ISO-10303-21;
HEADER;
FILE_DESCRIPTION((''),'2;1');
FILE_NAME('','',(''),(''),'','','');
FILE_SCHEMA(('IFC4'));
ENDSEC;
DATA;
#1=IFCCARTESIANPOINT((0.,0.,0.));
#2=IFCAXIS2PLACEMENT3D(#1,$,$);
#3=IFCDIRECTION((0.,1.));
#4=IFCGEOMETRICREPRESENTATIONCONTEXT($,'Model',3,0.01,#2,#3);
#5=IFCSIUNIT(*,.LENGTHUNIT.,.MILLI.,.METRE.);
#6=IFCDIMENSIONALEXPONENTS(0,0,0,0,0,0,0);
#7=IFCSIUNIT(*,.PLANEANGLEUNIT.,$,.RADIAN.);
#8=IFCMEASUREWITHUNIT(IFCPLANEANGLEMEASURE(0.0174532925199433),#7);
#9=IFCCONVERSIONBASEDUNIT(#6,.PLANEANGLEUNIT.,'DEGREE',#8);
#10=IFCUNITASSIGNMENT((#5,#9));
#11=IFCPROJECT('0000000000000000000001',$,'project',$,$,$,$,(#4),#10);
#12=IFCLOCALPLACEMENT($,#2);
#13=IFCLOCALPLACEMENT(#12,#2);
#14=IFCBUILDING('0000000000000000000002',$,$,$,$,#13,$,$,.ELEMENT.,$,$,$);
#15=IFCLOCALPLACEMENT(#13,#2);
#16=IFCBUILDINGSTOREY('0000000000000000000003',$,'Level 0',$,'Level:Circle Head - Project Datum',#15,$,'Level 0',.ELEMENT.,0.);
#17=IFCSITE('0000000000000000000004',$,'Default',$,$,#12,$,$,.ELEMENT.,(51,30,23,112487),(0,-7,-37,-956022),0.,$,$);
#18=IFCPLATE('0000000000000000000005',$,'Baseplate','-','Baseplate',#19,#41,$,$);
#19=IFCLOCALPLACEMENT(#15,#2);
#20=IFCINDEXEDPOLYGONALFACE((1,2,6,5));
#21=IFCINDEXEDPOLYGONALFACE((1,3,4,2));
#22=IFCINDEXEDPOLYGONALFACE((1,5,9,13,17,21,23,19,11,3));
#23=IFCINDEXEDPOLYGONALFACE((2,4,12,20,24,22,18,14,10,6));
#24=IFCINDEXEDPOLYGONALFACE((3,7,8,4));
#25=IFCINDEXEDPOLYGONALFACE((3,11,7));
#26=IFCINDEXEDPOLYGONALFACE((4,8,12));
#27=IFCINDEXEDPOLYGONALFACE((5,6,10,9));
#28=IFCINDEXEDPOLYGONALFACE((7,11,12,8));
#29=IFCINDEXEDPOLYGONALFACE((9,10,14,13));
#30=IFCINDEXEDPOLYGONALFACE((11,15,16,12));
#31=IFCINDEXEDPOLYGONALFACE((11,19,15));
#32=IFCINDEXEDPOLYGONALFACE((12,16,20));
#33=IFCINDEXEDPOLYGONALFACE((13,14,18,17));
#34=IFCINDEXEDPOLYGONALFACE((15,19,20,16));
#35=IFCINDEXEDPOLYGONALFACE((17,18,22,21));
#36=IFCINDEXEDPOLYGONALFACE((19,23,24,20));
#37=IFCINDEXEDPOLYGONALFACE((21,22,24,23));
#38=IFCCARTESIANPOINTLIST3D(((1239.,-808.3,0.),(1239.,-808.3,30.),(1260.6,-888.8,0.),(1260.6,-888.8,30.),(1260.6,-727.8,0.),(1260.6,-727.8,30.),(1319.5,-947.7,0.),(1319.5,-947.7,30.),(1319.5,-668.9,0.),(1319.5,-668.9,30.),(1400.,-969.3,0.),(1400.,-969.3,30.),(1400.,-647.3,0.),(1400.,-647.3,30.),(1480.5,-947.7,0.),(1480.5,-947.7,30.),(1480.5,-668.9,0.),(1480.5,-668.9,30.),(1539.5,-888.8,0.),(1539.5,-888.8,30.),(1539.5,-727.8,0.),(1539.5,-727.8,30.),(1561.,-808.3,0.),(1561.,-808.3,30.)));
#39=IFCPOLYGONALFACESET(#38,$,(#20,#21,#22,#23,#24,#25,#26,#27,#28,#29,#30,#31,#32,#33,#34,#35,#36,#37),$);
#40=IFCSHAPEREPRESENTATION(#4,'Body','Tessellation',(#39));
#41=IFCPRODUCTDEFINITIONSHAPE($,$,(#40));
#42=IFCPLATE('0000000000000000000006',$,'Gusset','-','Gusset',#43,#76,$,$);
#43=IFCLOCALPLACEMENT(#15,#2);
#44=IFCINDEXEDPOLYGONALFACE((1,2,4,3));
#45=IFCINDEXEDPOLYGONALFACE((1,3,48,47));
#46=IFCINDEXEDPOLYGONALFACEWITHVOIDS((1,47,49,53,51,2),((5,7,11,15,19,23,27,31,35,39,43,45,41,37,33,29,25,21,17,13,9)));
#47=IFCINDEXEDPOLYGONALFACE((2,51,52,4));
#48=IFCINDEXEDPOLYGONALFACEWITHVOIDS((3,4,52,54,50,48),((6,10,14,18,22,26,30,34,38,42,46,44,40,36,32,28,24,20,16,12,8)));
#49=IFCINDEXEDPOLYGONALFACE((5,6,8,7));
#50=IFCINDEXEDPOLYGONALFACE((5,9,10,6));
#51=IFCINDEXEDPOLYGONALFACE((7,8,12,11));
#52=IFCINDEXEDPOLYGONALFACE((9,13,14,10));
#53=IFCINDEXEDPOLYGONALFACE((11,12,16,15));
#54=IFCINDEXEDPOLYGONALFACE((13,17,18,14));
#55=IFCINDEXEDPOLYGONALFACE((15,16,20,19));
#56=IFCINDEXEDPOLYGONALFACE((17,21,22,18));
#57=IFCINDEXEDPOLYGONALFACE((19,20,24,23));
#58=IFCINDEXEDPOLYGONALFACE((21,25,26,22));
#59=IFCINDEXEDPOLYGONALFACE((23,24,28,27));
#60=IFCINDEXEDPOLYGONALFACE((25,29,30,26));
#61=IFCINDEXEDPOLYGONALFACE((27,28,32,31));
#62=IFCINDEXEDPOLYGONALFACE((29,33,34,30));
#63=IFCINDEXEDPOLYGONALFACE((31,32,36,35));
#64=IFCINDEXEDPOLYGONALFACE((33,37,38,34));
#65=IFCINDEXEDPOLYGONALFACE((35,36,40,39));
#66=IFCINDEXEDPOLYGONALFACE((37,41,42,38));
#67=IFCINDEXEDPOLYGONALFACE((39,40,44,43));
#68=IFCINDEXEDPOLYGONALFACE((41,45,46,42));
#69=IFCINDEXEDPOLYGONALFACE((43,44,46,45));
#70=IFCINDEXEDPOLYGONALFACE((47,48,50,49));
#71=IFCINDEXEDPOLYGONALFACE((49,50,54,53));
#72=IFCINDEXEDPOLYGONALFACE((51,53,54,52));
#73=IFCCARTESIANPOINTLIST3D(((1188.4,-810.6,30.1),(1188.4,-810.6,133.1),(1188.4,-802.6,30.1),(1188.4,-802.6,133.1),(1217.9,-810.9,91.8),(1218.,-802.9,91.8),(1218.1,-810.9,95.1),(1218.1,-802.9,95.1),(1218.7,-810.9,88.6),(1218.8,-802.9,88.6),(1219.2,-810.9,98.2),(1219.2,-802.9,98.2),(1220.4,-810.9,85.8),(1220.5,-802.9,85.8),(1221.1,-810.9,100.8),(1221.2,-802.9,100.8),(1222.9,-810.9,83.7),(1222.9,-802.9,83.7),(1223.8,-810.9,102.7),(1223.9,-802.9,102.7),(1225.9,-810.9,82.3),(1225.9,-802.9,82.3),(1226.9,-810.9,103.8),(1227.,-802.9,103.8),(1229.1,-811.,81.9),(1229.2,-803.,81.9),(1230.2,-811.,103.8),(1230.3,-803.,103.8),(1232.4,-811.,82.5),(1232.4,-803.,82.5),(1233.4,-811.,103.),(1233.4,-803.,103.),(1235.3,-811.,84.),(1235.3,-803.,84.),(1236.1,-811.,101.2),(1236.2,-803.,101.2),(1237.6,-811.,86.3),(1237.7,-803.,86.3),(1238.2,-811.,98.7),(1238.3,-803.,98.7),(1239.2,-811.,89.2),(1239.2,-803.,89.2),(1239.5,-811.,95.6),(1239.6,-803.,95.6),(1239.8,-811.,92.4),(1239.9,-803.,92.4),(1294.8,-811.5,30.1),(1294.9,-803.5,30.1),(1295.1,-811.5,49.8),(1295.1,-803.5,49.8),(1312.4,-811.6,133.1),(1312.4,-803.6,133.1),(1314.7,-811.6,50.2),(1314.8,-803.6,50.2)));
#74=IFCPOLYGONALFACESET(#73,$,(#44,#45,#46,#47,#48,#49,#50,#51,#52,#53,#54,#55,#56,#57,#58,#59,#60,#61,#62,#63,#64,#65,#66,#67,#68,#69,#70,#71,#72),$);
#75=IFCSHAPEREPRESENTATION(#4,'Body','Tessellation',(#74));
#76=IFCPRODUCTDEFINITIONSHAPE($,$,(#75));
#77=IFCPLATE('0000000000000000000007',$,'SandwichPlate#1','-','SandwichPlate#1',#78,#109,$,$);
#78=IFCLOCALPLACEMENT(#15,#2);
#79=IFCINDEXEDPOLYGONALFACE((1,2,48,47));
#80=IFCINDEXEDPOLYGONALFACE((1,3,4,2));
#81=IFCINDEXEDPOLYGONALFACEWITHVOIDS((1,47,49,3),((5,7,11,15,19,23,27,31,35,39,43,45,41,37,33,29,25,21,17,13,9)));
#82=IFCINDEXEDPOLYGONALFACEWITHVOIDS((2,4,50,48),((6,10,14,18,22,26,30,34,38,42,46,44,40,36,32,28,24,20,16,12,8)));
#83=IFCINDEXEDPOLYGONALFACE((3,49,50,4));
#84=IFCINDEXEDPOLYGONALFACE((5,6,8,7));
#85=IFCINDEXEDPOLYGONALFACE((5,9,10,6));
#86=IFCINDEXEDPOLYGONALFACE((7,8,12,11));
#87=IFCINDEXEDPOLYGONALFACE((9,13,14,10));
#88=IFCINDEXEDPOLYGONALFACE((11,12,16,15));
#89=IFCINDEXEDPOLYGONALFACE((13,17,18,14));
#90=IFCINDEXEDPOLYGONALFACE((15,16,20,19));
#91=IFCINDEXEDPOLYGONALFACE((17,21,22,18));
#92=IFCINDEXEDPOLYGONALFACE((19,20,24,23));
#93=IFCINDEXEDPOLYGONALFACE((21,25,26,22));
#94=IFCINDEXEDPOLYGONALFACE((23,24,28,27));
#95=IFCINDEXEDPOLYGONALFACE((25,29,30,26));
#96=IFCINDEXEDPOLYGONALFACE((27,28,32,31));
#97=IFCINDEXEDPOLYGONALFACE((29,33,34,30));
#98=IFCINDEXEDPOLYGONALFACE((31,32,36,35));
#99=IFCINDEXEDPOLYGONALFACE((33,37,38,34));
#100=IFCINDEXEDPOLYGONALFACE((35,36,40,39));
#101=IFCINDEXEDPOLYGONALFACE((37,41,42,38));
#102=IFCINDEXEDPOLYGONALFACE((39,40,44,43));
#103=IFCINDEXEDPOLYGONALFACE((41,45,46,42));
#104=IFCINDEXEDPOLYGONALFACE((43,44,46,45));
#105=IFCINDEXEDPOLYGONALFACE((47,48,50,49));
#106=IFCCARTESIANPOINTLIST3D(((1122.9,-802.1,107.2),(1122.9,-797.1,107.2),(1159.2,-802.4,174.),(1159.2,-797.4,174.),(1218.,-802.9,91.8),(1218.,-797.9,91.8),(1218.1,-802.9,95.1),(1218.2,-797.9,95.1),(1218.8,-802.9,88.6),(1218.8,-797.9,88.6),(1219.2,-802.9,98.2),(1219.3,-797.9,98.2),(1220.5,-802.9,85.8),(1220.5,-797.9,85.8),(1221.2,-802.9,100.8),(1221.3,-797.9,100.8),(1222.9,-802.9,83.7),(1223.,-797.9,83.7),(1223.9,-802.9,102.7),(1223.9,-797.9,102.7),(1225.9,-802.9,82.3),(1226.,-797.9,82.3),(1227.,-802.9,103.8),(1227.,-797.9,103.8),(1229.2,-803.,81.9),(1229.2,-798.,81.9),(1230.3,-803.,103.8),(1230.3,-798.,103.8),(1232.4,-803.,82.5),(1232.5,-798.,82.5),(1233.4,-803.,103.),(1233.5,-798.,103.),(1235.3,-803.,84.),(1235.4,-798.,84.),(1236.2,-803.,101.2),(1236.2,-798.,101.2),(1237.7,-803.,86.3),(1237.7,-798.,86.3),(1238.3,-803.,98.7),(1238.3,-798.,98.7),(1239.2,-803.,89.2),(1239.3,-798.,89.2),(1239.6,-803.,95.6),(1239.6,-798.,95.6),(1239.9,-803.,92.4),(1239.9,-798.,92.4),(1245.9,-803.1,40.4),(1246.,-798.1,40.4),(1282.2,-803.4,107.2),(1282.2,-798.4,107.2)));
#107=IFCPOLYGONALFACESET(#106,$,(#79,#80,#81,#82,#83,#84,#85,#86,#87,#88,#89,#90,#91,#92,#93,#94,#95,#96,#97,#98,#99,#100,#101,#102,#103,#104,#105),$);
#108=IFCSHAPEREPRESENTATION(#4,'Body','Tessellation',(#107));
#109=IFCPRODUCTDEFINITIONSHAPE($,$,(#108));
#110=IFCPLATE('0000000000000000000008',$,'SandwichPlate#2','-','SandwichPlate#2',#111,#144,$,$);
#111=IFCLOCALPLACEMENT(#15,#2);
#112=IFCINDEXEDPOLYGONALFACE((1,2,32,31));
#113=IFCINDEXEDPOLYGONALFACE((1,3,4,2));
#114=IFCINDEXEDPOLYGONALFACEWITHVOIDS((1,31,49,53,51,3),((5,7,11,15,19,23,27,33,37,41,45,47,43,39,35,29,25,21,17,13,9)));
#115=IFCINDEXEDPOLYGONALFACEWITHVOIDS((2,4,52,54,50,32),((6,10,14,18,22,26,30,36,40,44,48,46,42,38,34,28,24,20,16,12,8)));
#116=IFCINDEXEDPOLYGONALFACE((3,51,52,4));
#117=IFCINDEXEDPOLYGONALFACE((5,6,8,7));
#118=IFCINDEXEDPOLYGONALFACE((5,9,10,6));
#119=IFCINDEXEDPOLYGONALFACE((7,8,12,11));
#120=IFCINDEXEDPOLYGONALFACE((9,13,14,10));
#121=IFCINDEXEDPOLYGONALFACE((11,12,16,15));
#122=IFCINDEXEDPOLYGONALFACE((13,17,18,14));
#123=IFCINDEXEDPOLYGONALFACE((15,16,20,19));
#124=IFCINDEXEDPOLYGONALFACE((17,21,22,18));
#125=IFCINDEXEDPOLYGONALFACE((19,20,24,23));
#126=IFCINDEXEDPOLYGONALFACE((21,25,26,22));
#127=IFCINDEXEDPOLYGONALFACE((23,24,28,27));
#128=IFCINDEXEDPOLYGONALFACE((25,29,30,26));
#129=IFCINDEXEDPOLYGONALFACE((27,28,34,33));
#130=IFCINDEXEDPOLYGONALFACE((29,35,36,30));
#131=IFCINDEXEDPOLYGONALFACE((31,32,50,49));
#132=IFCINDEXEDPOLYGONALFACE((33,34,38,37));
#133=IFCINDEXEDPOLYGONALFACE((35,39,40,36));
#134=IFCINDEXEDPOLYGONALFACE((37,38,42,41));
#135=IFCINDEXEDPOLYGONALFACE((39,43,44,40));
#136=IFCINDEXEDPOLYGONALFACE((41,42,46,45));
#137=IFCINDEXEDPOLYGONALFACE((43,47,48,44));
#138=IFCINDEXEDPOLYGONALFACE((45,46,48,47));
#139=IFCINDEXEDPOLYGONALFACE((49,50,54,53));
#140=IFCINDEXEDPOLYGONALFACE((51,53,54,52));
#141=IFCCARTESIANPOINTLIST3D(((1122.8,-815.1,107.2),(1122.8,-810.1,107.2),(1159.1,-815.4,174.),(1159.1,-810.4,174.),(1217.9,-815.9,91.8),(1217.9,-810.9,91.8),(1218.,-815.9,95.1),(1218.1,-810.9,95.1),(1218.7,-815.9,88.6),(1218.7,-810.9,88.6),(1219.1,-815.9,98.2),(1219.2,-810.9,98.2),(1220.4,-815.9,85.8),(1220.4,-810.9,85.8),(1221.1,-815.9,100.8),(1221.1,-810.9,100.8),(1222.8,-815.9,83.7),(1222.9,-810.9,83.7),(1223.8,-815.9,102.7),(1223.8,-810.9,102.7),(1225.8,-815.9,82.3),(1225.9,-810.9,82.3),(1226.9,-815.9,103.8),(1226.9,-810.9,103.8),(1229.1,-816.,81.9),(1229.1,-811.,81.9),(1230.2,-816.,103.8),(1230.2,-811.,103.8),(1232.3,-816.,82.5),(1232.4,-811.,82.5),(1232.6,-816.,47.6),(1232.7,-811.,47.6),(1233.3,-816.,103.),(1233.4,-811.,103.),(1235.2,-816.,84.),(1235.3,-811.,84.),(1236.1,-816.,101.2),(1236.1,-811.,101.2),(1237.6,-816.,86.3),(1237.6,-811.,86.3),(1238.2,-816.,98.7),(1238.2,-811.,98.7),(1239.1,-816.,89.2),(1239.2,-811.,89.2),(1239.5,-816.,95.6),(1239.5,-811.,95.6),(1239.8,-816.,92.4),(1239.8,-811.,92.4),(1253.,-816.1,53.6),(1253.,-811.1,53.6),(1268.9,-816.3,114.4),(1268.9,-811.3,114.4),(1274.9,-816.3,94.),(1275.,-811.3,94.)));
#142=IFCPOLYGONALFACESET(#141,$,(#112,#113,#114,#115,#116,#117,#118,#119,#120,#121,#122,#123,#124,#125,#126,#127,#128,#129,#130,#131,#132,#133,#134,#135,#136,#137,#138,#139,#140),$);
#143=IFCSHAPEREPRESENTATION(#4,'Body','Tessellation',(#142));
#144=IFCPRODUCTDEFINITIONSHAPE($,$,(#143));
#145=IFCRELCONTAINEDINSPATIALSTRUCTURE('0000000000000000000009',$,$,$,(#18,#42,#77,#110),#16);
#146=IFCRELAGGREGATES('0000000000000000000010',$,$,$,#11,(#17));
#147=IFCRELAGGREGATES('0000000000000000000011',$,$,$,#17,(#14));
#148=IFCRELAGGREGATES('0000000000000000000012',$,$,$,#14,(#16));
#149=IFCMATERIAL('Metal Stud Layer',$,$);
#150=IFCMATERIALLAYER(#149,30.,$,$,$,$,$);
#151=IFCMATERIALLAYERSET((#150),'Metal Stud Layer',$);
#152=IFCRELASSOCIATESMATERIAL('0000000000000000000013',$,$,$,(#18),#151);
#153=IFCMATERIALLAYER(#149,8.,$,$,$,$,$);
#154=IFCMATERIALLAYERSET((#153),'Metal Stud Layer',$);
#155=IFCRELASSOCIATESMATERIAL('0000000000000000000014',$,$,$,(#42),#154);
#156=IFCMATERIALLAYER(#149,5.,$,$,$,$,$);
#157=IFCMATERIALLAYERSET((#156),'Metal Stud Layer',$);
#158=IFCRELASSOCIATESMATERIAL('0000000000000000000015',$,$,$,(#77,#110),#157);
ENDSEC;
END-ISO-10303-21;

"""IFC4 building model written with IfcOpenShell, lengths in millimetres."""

from ifc_helpers import new_model, entity, si_unit, converted_unit, point, direction, frame, frame_2d, origin, origin_with_axes, origin_2d_with_axis, place, context, project, spatial, polyline, circle_curve, line_curve, trimmed, segment, composite_curve, circle, outline, extrude, material, layer, layer_set, element, save


model = new_model("IFC4")

# Units and contexts
model_context = context("Model", 3, precision=0.01, world=origin(), true_north=direction((0.0, 1.0)))
ifc_project = project(units=[si_unit("LENGTHUNIT", "METRE", prefix="MILLI"), converted_unit("PLANEANGLEUNIT", "DEGREE", entity("IfcPlaneAngleMeasure", 0.0174532925199433), si_unit("PLANEANGLEUNIT", "RADIAN"), dimensions=[0, 0, 0, 0, 0, 0, 0])], contexts=[model_context])

# Site, building, storey
site_placement = place(None, origin())
site = spatial("IfcSite", under=ifc_project, at=site_placement, Name="Default", CompositionType="ELEMENT", RefLatitude=(51, 30, 23, 112487), RefLongitude=(0, -7, -37, -956022), RefElevation=0.0)
building_placement = place(site_placement, origin())
building = spatial("IfcBuilding", under=site, at=building_placement, CompositionType="ELEMENT")
storey_placement = place(building_placement, origin())
storey = spatial("IfcBuildingStorey", under=building, at=storey_placement, Name="Level 0", ObjectType="Level:Circle Head - Project Datum", LongName="Level 0", CompositionType="ELEMENT", Elevation=0.0)

# Plates, openings
ifc_material_1 = material(Name="Metal Stud Layer")
ifc_layer_1 = layer(ifc_material_1, 30.0)
ifc_layer_set_1 = layer_set([ifc_layer_1], Name="Metal Stud Layer")
plate_1_placement = place(storey_placement, frame((1480.5, -668.9, 30.0), z_axis=(0.0, 0.0, -1.0), x_axis=(0.866025, -0.5, 0.0)))
plate_1 = element("IfcPlate", 1, at=plate_1_placement, inside=storey, material=ifc_layer_set_1, Name="Baseplate", Description="-", ObjectType="Baseplate", context=model_context, shape_type="SweptSolid", body=[
    extrude(outline(polyline([(161.0, 0.0), (161.0, 322.0), (-161.0, 322.0), (-161.0, 0.0), (161.0, 0.0)])), origin_with_axes(), (0.0, 0.0, 1.0), 30.0),
])
opening_1_placement = place(plate_1_placement, frame((0.0, 0.0, 0.0), z_axis=(0.0, 0.0, 1.0), x_axis=(1.0, 0.0, 0.0)))
element("IfcOpeningElement", 2, at=opening_1_placement, cuts=plate_1, ObjectType="Opening", context=model_context, shape_type="SweptSolid", body=[
    extrude(outline(composite_curve([segment(trimmed(line_curve((161.0, 0.0), (0.0, 1.0), 161.0), [point((161.0, 0.0))], [point((161.0, 161.0))], True, "CARTESIAN"), True, "CONTINUOUS"), segment(trimmed(circle_curve(frame_2d((0.0, 161.0), x_axis=(-1.0, 0.0)), 161.0), [point((161.0, 161.0))], [point((0.0, 0.0))], False, "CARTESIAN"), True, "CONTINUOUS"), segment(trimmed(line_curve((0.0, 0.0), (1.0, 0.0), 161.0), [point((0.0, 0.0))], [point((161.0, 0.0))], True, "CARTESIAN"), True, "CONTINUOUS")], self_intersect="UNKNOWN")), origin(), (0.0, 0.0, 1.0), 30.0),
])
opening_2_placement = place(plate_1_placement, frame((0.0, 0.0, 0.0), z_axis=(0.0, 0.0, 1.0), x_axis=(1.0, 0.0, 0.0)))
element("IfcOpeningElement", 3, at=opening_2_placement, cuts=plate_1, ObjectType="Opening", context=model_context, shape_type="SweptSolid", body=[
    extrude(outline(composite_curve([segment(trimmed(line_curve((161.0, 322.0), (-1.0, 0.0), 161.0), [point((161.0, 322.0))], [point((0.0, 322.0))], True, "CARTESIAN"), True, "CONTINUOUS"), segment(trimmed(circle_curve(frame_2d((0.0, 161.0), x_axis=(-1.0, 0.0)), 161.0), [point((0.0, 322.0))], [point((161.0, 161.0))], False, "CARTESIAN"), True, "CONTINUOUS"), segment(trimmed(line_curve((161.0, 161.0), (0.0, 1.0), 161.0), [point((161.0, 161.0))], [point((161.0, 322.0))], True, "CARTESIAN"), True, "CONTINUOUS")], self_intersect="UNKNOWN")), origin(), (0.0, 0.0, 1.0), 30.0),
])
opening_3_placement = place(plate_1_placement, frame((0.0, 0.0, 0.0), z_axis=(0.0, 0.0, 1.0), x_axis=(1.0, 0.0, 0.0)))
element("IfcOpeningElement", 4, at=opening_3_placement, cuts=plate_1, ObjectType="Opening", context=model_context, shape_type="SweptSolid", body=[
    extrude(outline(composite_curve([segment(trimmed(line_curve((-161.0, 322.0), (0.0, -1.0), 161.0), [point((-161.0, 322.0))], [point((-161.0, 161.0))], True, "CARTESIAN"), True, "CONTINUOUS"), segment(trimmed(circle_curve(frame_2d((0.0, 161.0), x_axis=(-1.0, 0.0)), 161.0), [point((-161.0, 161.0))], [point((0.0, 322.0))], False, "CARTESIAN"), True, "CONTINUOUS"), segment(trimmed(line_curve((0.0, 322.0), (-1.0, 0.0), 161.0), [point((0.0, 322.0))], [point((-161.0, 322.0))], True, "CARTESIAN"), True, "CONTINUOUS")], self_intersect="UNKNOWN")), origin(), (0.0, 0.0, 1.0), 30.0),
])
opening_4_placement = place(plate_1_placement, frame((0.0, 0.0, 0.0), z_axis=(0.0, 0.0, 1.0), x_axis=(1.0, 0.0, 0.0)))
element("IfcOpeningElement", 5, at=opening_4_placement, cuts=plate_1, ObjectType="Opening", context=model_context, shape_type="SweptSolid", body=[
    extrude(outline(composite_curve([segment(trimmed(line_curve((-161.0, 0.0), (1.0, 0.0), 161.0), [point((-161.0, 0.0))], [point((0.0, 0.0))], True, "CARTESIAN"), True, "CONTINUOUS"), segment(trimmed(circle_curve(frame_2d((0.0, 161.0), x_axis=(-1.0, 0.0)), 161.0), [point((0.0, 0.0))], [point((-161.0, 161.0))], False, "CARTESIAN"), True, "CONTINUOUS"), segment(trimmed(line_curve((-161.0, 161.0), (0.0, -1.0), 161.0), [point((-161.0, 161.0))], [point((-161.0, 0.0))], True, "CARTESIAN"), True, "CONTINUOUS")], self_intersect="UNKNOWN")), origin(), (0.0, 0.0, 1.0), 30.0),
])
ifc_layer_2 = layer(ifc_material_1, 8.0)
ifc_layer_set_2 = layer_set([ifc_layer_2], Name="Metal Stud Layer")
plate_2_placement = place(storey_placement, frame((1309.2, -803.6, 143.6), z_axis=(-0.007837, -0.999969, 0.0), x_axis=(-0.999419, 0.007833, -0.033166)))
plate_2 = element("IfcPlate", 6, at=plate_2_placement, inside=storey, material=ifc_layer_set_2, Name="Gusset", Description="-", ObjectType="Gusset", context=model_context, shape_type="SweptSolid", body=[
    extrude(outline(polyline([(-2.5, 93.5), (-2.9, 10.5), (121.1, 6.4), (124.5, 109.4), (18.1, 112.9), (17.2, 93.2), (-2.5, 93.5)])), origin_with_axes(), (0.0, 0.0, 1.0), 8.0),
])
opening_5_placement = place(plate_2_placement, origin_with_axes())
element("IfcOpeningElement", 7, at=opening_5_placement, cuts=plate_2, ObjectType="Opening", context=model_context, shape_type="SweptSolid", body=[
    extrude(outline(composite_curve([segment(trimmed(line_curve((17.2, 93.2), (-0.999857, 0.016904), 19.685532), [point((17.2, 93.2))], [point((-2.5, 93.5))], True, "CARTESIAN"), True, "CONTINUOUS"), segment(trimmed(circle_curve(frame_2d((-2.2, 113.8), x_axis=(1.0, 0.0)), 20.3), [point((-2.5, 93.5))], [point((18.1, 112.9))], True, "CARTESIAN"), True, "CONTINUOUS"), segment(trimmed(line_curve((18.1, 112.9), (-0.046684, -0.99891), 19.685532), [point((18.1, 112.9))], [point((17.2, 93.2))], True, "CARTESIAN"), True, "CONTINUOUS")], self_intersect="UNKNOWN")), origin(), (0.0, 0.0, 1.0), 8.0),
])
opening_6_placement = place(plate_2_placement, frame((81.9, 48.0, 8.5), z_axis=(0.0, 0.0, -1.0), x_axis=(0.862503, -0.506052, 0.0)))
element("IfcOpeningElement", 8, at=opening_6_placement, cuts=plate_2, ObjectType="Opening", context=model_context, shape_type="SweptSolid", body=[
    extrude(circle(Radius=11.0, at=origin_2d_with_axis()), origin(), (0.0, 0.0, 1.0), 9.0),
])

# Plates, openings
ifc_layer_3 = layer(ifc_material_1, 5.0)
ifc_layer_set_3 = layer_set([ifc_layer_3], Name="Metal Stud Layer")
plate_3_placement = place(storey_placement, frame((1282.2, -803.4, 107.2), z_axis=(0.007837, 0.999969, 0.0), x_axis=(-0.477154, 0.00374, -0.878812)))
plate_3 = element("IfcPlate", 9, at=plate_3_placement, inside=storey, material=ifc_layer_set_3, Name="SandwichPlate#1", Description="-", ObjectType="SandwichPlate#1", context=model_context, shape_type="SweptSolid", body=[
    extrude(outline(polyline([(0.0, 0.0), (76.0, 0.0), (76.0, 140.0), (0.0, 140.0), (0.0, 0.0)])), origin_with_axes(), (0.0, 0.0, 1.0), 5.0),
])
opening_7_placement = place(plate_3_placement, frame((38.0, 40.0, -0.5), z_axis=(0.0, 0.0, 1.0), x_axis=(0.0, 1.0, 0.0)))
element("IfcOpeningElement", 10, at=opening_7_placement, cuts=plate_3, ObjectType="Opening", context=model_context, shape_type="SweptSolid", body=[
    extrude(circle(Radius=11.0, at=origin_2d_with_axis()), origin(), (0.0, 0.0, 1.0), 6.0),
])
plate_4_placement = place(storey_placement, frame((1282.1, -816.4, 107.2), z_axis=(0.007837, 0.999969, 0.0), x_axis=(-0.477154, 0.00374, -0.878812)))
plate_4 = element("IfcPlate", 11, at=plate_4_placement, inside=storey, material=ifc_layer_set_3, Name="SandwichPlate#2", Description="-", ObjectType="SandwichPlate#2", context=model_context, shape_type="SweptSolid", body=[
    extrude(outline(polyline([(15.0, 0.0), (61.0, 0.0), (76.0, 15.0), (76.0, 140.0), (0.0, 140.0), (0.0, 15.0), (15.0, 0.0)])), origin_with_axes(), (0.0, 0.0, 1.0), 5.0),
])
opening_8_placement = place(plate_4_placement, frame((38.0, 40.0, -0.5), z_axis=(0.0, 0.0, 1.0), x_axis=(0.0, 1.0, 0.0)))
element("IfcOpeningElement", 12, at=opening_8_placement, cuts=plate_4, ObjectType="Opening", context=model_context, shape_type="SweptSolid", body=[
    extrude(circle(Radius=11.0, at=origin_2d_with_axis()), origin(), (0.0, 0.0, 1.0), 6.0),
])

save(model, "model.ifc")
